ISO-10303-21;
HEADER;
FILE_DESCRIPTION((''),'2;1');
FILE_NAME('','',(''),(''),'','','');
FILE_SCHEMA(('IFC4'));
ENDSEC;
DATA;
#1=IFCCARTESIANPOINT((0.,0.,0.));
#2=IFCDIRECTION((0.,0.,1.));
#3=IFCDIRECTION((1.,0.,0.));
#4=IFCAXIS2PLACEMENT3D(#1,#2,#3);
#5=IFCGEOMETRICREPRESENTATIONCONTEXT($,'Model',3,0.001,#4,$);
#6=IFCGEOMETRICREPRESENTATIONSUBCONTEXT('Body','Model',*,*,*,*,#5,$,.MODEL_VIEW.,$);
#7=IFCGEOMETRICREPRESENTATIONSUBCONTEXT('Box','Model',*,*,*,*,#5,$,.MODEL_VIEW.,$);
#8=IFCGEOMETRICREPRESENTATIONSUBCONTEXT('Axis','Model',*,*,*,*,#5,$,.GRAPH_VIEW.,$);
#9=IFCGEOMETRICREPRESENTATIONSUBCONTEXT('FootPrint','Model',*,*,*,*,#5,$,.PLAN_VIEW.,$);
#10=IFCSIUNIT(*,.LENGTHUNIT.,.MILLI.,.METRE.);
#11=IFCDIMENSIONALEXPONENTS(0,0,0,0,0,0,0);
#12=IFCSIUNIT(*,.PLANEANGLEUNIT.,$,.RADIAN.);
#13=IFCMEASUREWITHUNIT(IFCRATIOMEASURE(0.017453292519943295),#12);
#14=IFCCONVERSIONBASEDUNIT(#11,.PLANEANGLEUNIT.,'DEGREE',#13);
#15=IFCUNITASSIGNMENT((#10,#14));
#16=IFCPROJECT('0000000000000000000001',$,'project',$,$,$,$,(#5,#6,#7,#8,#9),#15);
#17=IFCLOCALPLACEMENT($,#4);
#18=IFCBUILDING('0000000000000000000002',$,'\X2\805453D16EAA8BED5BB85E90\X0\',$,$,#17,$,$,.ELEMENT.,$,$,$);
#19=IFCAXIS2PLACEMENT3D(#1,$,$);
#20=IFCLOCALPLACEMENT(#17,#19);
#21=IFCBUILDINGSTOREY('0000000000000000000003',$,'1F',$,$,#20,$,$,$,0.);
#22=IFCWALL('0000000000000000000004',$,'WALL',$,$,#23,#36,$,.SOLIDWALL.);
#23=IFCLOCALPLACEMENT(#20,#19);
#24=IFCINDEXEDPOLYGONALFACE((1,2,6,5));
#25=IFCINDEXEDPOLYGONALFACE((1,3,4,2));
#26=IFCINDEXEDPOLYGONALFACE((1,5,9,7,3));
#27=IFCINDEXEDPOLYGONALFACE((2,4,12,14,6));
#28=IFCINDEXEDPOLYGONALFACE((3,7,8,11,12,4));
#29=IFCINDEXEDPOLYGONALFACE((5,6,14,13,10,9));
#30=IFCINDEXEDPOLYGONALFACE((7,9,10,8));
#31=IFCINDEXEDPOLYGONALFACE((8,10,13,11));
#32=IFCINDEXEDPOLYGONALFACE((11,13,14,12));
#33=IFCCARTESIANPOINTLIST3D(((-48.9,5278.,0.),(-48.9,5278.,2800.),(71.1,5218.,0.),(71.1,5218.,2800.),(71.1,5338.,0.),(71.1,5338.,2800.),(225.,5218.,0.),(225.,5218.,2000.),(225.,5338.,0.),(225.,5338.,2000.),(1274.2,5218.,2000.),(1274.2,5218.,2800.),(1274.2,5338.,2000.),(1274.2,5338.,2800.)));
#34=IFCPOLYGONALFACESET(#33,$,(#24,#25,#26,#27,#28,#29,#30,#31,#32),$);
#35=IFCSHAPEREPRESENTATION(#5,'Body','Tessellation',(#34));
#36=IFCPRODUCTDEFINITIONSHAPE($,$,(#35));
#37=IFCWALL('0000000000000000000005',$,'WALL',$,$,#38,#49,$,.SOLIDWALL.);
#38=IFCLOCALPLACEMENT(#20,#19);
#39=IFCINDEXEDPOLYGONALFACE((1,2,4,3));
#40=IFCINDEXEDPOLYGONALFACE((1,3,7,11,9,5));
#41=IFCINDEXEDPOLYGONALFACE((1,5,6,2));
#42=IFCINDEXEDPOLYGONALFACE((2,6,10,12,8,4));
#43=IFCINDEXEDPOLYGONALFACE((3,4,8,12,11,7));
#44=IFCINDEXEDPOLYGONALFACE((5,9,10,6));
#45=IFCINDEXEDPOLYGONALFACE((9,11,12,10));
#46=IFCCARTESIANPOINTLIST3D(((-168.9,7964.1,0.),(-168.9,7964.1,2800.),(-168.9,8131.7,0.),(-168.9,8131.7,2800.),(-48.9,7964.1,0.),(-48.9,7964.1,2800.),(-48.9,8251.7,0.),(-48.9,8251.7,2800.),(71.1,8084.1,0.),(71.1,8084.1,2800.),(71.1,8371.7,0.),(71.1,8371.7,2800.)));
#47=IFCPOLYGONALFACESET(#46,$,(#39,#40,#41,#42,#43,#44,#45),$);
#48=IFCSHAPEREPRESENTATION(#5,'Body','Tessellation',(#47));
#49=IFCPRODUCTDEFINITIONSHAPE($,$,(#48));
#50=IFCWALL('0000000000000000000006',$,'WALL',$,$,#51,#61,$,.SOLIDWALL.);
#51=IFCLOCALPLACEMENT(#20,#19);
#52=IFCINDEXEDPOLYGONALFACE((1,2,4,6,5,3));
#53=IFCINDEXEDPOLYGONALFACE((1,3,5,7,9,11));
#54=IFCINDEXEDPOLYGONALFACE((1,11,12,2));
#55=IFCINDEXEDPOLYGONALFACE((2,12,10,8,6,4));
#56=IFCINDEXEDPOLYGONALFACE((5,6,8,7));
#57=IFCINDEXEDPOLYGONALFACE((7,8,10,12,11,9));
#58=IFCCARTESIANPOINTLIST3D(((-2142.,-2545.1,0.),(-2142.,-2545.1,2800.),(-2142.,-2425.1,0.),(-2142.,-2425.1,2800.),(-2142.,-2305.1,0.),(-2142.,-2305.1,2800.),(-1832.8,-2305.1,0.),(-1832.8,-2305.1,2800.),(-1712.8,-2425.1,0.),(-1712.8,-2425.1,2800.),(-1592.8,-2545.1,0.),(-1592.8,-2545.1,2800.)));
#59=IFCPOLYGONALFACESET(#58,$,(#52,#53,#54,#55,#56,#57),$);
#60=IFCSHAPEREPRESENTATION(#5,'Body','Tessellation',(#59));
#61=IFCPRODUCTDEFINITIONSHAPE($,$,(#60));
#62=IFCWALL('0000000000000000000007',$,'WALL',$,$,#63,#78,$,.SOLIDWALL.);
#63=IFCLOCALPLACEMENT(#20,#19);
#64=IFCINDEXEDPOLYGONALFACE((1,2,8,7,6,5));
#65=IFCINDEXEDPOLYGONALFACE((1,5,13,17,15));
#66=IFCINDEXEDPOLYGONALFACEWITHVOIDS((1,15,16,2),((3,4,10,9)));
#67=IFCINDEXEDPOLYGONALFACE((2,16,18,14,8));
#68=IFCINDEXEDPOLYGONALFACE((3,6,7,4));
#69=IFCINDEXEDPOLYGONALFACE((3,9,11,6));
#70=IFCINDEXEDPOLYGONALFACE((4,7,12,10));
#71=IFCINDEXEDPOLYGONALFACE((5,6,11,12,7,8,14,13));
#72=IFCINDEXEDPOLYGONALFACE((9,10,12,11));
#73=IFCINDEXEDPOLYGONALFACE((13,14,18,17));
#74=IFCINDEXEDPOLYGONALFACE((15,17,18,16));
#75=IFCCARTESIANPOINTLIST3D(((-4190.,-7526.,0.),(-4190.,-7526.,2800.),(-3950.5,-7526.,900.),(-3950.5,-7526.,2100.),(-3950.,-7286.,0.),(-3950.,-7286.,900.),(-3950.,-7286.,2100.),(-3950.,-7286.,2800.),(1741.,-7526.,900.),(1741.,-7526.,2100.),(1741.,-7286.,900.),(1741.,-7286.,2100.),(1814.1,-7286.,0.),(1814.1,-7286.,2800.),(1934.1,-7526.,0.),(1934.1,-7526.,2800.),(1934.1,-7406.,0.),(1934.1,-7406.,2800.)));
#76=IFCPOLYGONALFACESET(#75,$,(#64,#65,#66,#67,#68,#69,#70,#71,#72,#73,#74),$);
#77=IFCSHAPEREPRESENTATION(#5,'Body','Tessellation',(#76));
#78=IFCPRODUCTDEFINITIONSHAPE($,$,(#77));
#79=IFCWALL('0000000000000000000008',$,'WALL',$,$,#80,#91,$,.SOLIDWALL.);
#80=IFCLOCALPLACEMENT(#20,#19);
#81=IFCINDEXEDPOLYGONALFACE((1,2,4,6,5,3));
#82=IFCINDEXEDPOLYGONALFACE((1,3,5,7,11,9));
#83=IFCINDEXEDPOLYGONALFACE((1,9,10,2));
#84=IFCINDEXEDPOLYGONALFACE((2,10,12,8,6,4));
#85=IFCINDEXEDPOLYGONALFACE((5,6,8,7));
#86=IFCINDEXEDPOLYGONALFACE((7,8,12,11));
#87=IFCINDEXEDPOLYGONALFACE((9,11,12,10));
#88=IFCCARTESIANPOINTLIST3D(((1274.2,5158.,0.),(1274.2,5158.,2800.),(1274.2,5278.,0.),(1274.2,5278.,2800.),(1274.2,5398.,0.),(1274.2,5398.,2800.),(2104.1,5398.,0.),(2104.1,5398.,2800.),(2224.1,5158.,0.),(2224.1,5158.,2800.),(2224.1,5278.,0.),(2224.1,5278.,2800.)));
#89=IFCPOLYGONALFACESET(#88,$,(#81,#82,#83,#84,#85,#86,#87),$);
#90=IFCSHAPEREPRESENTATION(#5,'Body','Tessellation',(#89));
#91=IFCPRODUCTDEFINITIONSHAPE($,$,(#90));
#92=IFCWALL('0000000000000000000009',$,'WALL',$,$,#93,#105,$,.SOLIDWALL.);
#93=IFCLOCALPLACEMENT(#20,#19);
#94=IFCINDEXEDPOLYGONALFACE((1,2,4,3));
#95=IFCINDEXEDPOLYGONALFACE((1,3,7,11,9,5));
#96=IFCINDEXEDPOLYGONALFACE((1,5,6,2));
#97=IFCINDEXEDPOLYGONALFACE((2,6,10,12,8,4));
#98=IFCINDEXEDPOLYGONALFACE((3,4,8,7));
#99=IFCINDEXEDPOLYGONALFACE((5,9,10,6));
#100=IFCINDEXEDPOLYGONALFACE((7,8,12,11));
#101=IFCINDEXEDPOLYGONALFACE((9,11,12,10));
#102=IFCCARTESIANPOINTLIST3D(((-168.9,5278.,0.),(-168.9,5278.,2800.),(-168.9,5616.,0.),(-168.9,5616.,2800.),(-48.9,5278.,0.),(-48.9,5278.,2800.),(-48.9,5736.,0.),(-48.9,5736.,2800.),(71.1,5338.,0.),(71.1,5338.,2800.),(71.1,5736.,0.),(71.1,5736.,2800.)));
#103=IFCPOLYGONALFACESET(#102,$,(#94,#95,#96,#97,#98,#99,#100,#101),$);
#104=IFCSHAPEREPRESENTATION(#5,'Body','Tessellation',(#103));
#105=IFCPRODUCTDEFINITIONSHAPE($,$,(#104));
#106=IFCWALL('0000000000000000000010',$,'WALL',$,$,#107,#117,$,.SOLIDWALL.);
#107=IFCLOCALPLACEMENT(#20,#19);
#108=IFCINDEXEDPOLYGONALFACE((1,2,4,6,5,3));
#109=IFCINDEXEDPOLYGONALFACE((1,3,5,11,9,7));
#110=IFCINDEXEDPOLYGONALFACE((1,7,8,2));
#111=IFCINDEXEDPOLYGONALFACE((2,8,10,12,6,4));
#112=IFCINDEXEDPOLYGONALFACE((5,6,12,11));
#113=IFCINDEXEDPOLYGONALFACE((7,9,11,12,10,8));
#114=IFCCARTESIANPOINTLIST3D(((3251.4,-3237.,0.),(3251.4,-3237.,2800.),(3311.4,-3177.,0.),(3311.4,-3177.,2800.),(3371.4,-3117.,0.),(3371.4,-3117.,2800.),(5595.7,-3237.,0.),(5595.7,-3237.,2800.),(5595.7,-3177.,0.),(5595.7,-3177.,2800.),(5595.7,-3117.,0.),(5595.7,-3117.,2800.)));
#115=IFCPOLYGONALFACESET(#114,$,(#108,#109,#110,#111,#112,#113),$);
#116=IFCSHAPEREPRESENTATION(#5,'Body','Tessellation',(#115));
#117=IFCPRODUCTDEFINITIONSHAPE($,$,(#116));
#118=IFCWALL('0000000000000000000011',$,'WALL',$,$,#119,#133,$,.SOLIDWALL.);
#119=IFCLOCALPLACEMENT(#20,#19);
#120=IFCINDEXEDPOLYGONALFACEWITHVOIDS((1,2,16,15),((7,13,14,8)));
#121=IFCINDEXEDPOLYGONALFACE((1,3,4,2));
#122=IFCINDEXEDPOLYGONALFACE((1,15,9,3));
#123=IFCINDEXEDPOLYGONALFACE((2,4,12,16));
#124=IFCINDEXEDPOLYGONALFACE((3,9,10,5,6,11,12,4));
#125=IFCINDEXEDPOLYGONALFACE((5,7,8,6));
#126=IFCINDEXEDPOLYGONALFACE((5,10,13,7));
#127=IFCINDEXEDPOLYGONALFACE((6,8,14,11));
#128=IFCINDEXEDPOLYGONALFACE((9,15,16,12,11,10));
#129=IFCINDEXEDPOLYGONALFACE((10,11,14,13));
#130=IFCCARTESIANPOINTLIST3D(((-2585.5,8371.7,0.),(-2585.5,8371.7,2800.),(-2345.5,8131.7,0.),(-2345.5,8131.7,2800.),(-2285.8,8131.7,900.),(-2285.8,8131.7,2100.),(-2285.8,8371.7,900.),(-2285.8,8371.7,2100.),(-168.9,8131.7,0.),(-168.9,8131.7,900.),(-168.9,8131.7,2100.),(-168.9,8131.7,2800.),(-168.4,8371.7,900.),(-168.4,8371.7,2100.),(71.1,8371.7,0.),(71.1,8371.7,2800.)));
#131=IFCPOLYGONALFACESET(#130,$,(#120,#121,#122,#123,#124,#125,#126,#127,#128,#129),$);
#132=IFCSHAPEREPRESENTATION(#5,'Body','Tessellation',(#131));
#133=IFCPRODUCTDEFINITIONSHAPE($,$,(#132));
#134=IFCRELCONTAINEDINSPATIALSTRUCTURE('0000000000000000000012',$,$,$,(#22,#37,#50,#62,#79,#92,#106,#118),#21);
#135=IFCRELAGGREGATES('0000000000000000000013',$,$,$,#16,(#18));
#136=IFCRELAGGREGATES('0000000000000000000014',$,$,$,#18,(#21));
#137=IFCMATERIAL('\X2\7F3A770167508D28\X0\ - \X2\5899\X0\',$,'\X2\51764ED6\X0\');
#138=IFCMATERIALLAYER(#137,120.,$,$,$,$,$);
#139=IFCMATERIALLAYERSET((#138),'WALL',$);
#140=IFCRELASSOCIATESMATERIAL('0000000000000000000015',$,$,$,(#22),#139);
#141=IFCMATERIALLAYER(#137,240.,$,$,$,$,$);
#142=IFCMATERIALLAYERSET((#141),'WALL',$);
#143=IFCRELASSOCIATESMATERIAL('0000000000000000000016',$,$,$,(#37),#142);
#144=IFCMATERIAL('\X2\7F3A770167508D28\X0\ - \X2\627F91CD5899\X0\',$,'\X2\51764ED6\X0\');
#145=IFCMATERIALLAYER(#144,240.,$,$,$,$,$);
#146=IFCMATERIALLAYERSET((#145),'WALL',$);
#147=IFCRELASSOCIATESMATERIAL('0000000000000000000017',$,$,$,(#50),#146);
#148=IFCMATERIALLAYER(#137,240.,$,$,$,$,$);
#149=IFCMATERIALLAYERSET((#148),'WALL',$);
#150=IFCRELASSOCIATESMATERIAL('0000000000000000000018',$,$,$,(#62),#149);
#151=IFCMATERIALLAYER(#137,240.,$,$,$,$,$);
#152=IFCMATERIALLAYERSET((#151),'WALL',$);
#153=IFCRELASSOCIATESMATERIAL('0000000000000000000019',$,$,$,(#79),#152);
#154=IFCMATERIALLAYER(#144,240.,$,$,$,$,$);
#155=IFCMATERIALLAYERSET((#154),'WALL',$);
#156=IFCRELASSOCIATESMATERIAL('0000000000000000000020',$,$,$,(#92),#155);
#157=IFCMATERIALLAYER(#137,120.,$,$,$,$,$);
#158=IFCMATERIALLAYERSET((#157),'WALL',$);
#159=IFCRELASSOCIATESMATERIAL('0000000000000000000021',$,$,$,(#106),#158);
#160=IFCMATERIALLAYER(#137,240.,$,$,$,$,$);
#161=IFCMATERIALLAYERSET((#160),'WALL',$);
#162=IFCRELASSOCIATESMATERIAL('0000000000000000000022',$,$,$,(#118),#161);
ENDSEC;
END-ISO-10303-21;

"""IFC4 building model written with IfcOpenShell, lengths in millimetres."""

from ifc_helpers import new_model, entity, si_unit, converted_unit, frame, origin, origin_with_axes, place, context, subcontext, project, spatial, polyline, segment, composite_curve, outline, extrude, material, layer, layer_set, layer_usage, element, save


model = new_model("IFC4")

# Units and contexts
model_context = context("Model", 3, precision=0.001, world=origin_with_axes())
body_context = subcontext(model_context, "Body", "Model", "MODEL_VIEW")
box_context = subcontext(model_context, "Box", "Model", "MODEL_VIEW")
axis_context = subcontext(model_context, "Axis", "Model", "GRAPH_VIEW")
footprint_context = subcontext(model_context, "FootPrint", "Model", "PLAN_VIEW")
ifc_project = project(units=[si_unit("LENGTHUNIT", "METRE", prefix="MILLI"), converted_unit("PLANEANGLEUNIT", "DEGREE", entity("IfcRatioMeasure", 0.017453292519943295), si_unit("PLANEANGLEUNIT", "RADIAN"), dimensions=[0, 0, 0, 0, 0, 0, 0])], contexts=[model_context, body_context, box_context, axis_context, footprint_context])

# Building, storey
building_placement = place(None, origin_with_axes())
building = spatial("IfcBuilding", under=ifc_project, at=building_placement, Name="联发溪语宸庐", CompositionType="ELEMENT")
storey_placement = place(building_placement, origin())
storey = spatial("IfcBuildingStorey", under=building, at=storey_placement, Name="1F", Elevation=0.0)

# Wall, opening
ifc_material_1 = material(Name="缺省材质 - 墙", Category="其他")
ifc_layer_1 = layer(ifc_material_1, 120.0)
ifc_layer_set_1 = layer_set([ifc_layer_1], Name="WALL")
ifc_layer_usage_1 = layer_usage(ifc_layer_set_1, "AXIS2", "NEGATIVE", 60.0)
wall_1_placement = place(None, origin_with_axes())
wall_1 = element("IfcWall", 1, at=wall_1_placement, inside=storey, material=ifc_layer_usage_1, Name="WALL", PredefinedType="SOLIDWALL", context=model_context, shape_type="SweptSolid", body=[
    extrude(outline(composite_curve([segment(polyline([(1274.2, 5278.0), (1274.2, 5338.0)]), True, "CONTINUOUS"), segment(polyline([(1274.2, 5338.0), (71.1, 5338.0)]), True, "CONTINUOUS"), segment(polyline([(71.1, 5338.0), (-48.9, 5278.0)]), True, "CONTINUOUS"), segment(polyline([(-48.9, 5278.0), (71.1, 5218.0)]), True, "CONTINUOUS"), segment(polyline([(71.1, 5218.0), (1274.2, 5218.0)]), True, "CONTINUOUS"), segment(polyline([(1274.2, 5218.0), (1274.2, 5278.0)]), True, "CONTINUOUS")], self_intersect=False)), origin(), (0.0, 0.0, 1.0), 2800.0),
])
opening_1_placement = place(None, origin_with_axes())
element("IfcOpeningElement", 2, at=opening_1_placement, cuts=wall_1, ObjectType="OPENING", PredefinedType="OPENING", context=model_context, shape_type="SweptSolid", body=[
    extrude(outline(composite_curve([segment(polyline([(225.0, 5218.0), (1274.2, 5218.0)]), True, "CONTINUOUS"), segment(polyline([(1274.2, 5218.0), (1274.2, 5338.0)]), True, "CONTINUOUS"), segment(polyline([(1274.2, 5338.0), (225.0, 5338.0)]), True, "CONTINUOUS"), segment(polyline([(225.0, 5338.0), (225.0, 5218.0)]), True, "CONTINUOUS")], self_intersect=False)), origin_with_axes(), (0.0, 0.0, 1.0), 2000.0),
])

# Walls
ifc_layer_2 = layer(ifc_material_1, 240.0)
ifc_layer_set_2 = layer_set([ifc_layer_2], Name="WALL")
ifc_layer_usage_2 = layer_usage(ifc_layer_set_2, "AXIS2", "NEGATIVE", 120.0)
wall_2_placement = place(None, origin_with_axes())
element("IfcWall", 3, at=wall_2_placement, inside=storey, material=ifc_layer_usage_2, Name="WALL", PredefinedType="SOLIDWALL", context=model_context, shape_type="SweptSolid", body=[
    extrude(outline(composite_curve([segment(polyline([(-48.9, 7964.1), (71.1, 8084.1)]), True, "CONTINUOUS"), segment(polyline([(71.1, 8084.1), (71.1, 8371.7)]), True, "CONTINUOUS"), segment(polyline([(71.1, 8371.7), (-48.9, 8251.7)]), True, "CONTINUOUS"), segment(polyline([(-48.9, 8251.7), (-168.9, 8131.7)]), True, "CONTINUOUS"), segment(polyline([(-168.9, 8131.7), (-168.9, 7964.1)]), True, "CONTINUOUS"), segment(polyline([(-168.9, 7964.1), (-48.9, 7964.1)]), True, "CONTINUOUS")], self_intersect=False)), origin(), (0.0, 0.0, 1.0), 2800.0),
])
ifc_material_2 = material(Name="缺省材质 - 承重墙", Category="其他")
ifc_layer_3 = layer(ifc_material_2, 240.0)
ifc_layer_set_3 = layer_set([ifc_layer_3], Name="WALL")
ifc_layer_usage_3 = layer_usage(ifc_layer_set_3, "AXIS2", "NEGATIVE", 120.0)
wall_3_placement = place(None, origin_with_axes())
element("IfcWall", 4, at=wall_3_placement, inside=storey, material=ifc_layer_usage_3, Name="WALL", PredefinedType="SOLIDWALL", context=model_context, shape_type="SweptSolid", body=[
    extrude(outline(composite_curve([segment(polyline([(-2142.0, -2425.1), (-2142.0, -2545.1)]), True, "CONTINUOUS"), segment(polyline([(-2142.0, -2545.1), (-1592.8, -2545.1)]), True, "CONTINUOUS"), segment(polyline([(-1592.8, -2545.1), (-1712.8, -2425.1)]), True, "CONTINUOUS"), segment(polyline([(-1712.8, -2425.1), (-1832.8, -2305.1)]), True, "CONTINUOUS"), segment(polyline([(-1832.8, -2305.1), (-2142.0, -2305.1)]), True, "CONTINUOUS"), segment(polyline([(-2142.0, -2305.1), (-2142.0, -2425.1)]), True, "CONTINUOUS")], self_intersect=False)), origin(), (0.0, 0.0, 1.0), 2800.0),
])

# Wall, opening
ifc_layer_4 = layer(ifc_material_1, 240.0)
ifc_layer_set_4 = layer_set([ifc_layer_4], Name="WALL")
ifc_layer_usage_4 = layer_usage(ifc_layer_set_4, "AXIS2", "NEGATIVE", 120.0)
wall_4_placement = place(None, origin_with_axes())
wall_4 = element("IfcWall", 5, at=wall_4_placement, inside=storey, material=ifc_layer_usage_4, Name="WALL", PredefinedType="SOLIDWALL", context=model_context, shape_type="SweptSolid", body=[
    extrude(outline(composite_curve([segment(polyline([(-4070.0, -7406.0), (-4190.0, -7526.0)]), True, "CONTINUOUS"), segment(polyline([(-4190.0, -7526.0), (1934.1, -7526.0)]), True, "CONTINUOUS"), segment(polyline([(1934.1, -7526.0), (1934.1, -7406.0)]), True, "CONTINUOUS"), segment(polyline([(1934.1, -7406.0), (1814.1, -7286.0)]), True, "CONTINUOUS"), segment(polyline([(1814.1, -7286.0), (-3950.0, -7286.0)]), True, "CONTINUOUS"), segment(polyline([(-3950.0, -7286.0), (-4070.0, -7406.0)]), True, "CONTINUOUS")], self_intersect=False)), origin(), (0.0, 0.0, 1.0), 2800.0),
])
opening_2_placement = place(None, origin_with_axes())
element("IfcOpeningElement", 6, at=opening_2_placement, cuts=wall_4, ObjectType="OPENING", PredefinedType="OPENING", context=model_context, shape_type="SweptSolid", body=[
    extrude(outline(composite_curve([segment(polyline([(1741.0, -7286.0), (-3950.0, -7286.0)]), True, "CONTINUOUS"), segment(polyline([(-3950.0, -7286.0), (-3950.5, -7526.0)]), True, "CONTINUOUS"), segment(polyline([(-3950.5, -7526.0), (1741.0, -7526.0)]), True, "CONTINUOUS"), segment(polyline([(1741.0, -7526.0), (1741.0, -7286.0)]), True, "CONTINUOUS")], self_intersect=False)), frame((0.0, 0.0, 900.0), z_axis=(0.0, 0.0, 1.0), x_axis=(1.0, 0.0, 0.0)), (0.0, 0.0, 1.0), 1200.0),
])

# Walls
ifc_layer_5 = layer(ifc_material_1, 240.0)
ifc_layer_set_5 = layer_set([ifc_layer_5], Name="WALL")
ifc_layer_usage_5 = layer_usage(ifc_layer_set_5, "AXIS2", "NEGATIVE", 120.0)
wall_5_placement = place(None, origin_with_axes())
element("IfcWall", 7, at=wall_5_placement, inside=storey, material=ifc_layer_usage_5, Name="WALL", PredefinedType="SOLIDWALL", context=model_context, shape_type="SweptSolid", body=[
    extrude(outline(composite_curve([segment(polyline([(2224.1, 5278.0), (2104.1, 5398.0)]), True, "CONTINUOUS"), segment(polyline([(2104.1, 5398.0), (1274.2, 5398.0)]), True, "CONTINUOUS"), segment(polyline([(1274.2, 5398.0), (1274.2, 5278.0)]), True, "CONTINUOUS"), segment(polyline([(1274.2, 5278.0), (1274.2, 5158.0)]), True, "CONTINUOUS"), segment(polyline([(1274.2, 5158.0), (2224.1, 5158.0)]), True, "CONTINUOUS"), segment(polyline([(2224.1, 5158.0), (2224.1, 5278.0)]), True, "CONTINUOUS")], self_intersect=False)), origin(), (0.0, 0.0, 1.0), 2800.0),
])
ifc_layer_6 = layer(ifc_material_2, 240.0)
ifc_layer_set_6 = layer_set([ifc_layer_6], Name="WALL")
ifc_layer_usage_6 = layer_usage(ifc_layer_set_6, "AXIS2", "NEGATIVE", 120.0)
wall_6_placement = place(None, origin_with_axes())
element("IfcWall", 8, at=wall_6_placement, inside=storey, material=ifc_layer_usage_6, Name="WALL", PredefinedType="SOLIDWALL", context=model_context, shape_type="SweptSolid", body=[
    extrude(outline(composite_curve([segment(polyline([(-48.9, 5278.0), (71.1, 5338.0)]), True, "CONTINUOUS"), segment(polyline([(71.1, 5338.0), (71.1, 5736.0)]), True, "CONTINUOUS"), segment(polyline([(71.1, 5736.0), (-48.9, 5736.0)]), True, "CONTINUOUS"), segment(polyline([(-48.9, 5736.0), (-168.9, 5616.0)]), True, "CONTINUOUS"), segment(polyline([(-168.9, 5616.0), (-168.9, 5278.0)]), True, "CONTINUOUS"), segment(polyline([(-168.9, 5278.0), (-48.9, 5278.0)]), True, "CONTINUOUS")], self_intersect=False)), origin(), (0.0, 0.0, 1.0), 2800.0),
])
ifc_layer_7 = layer(ifc_material_1, 120.0)
ifc_layer_set_7 = layer_set([ifc_layer_7], Name="WALL")
ifc_layer_usage_7 = layer_usage(ifc_layer_set_7, "AXIS2", "NEGATIVE", 60.0)
wall_7_placement = place(None, origin_with_axes())
element("IfcWall", 9, at=wall_7_placement, inside=storey, material=ifc_layer_usage_7, Name="WALL", PredefinedType="SOLIDWALL", context=model_context, shape_type="SweptSolid", body=[
    extrude(outline(composite_curve([segment(polyline([(3311.4, -3177.0), (3251.4, -3237.0)]), True, "CONTINUOUS"), segment(polyline([(3251.4, -3237.0), (5595.7, -3237.0)]), True, "CONTINUOUS"), segment(polyline([(5595.7, -3237.0), (5595.7, -3177.0)]), True, "CONTINUOUS"), segment(polyline([(5595.7, -3177.0), (5595.7, -3117.0)]), True, "CONTINUOUS"), segment(polyline([(5595.7, -3117.0), (3371.4, -3117.0)]), True, "CONTINUOUS"), segment(polyline([(3371.4, -3117.0), (3311.4, -3177.0)]), True, "CONTINUOUS")], self_intersect=False)), origin(), (0.0, 0.0, 1.0), 2800.0),
])

# Wall, opening
ifc_layer_8 = layer(ifc_material_1, 240.0)
ifc_layer_set_8 = layer_set([ifc_layer_8], Name="WALL")
ifc_layer_usage_8 = layer_usage(ifc_layer_set_8, "AXIS2", "NEGATIVE", 120.0)
wall_8_placement = place(None, origin_with_axes())
wall_8 = element("IfcWall", 10, at=wall_8_placement, inside=storey, material=ifc_layer_usage_8, Name="WALL", PredefinedType="SOLIDWALL", context=model_context, shape_type="SweptSolid", body=[
    extrude(outline(composite_curve([segment(polyline([(-2465.5, 8251.7), (-2345.5, 8131.7)]), True, "CONTINUOUS"), segment(polyline([(-2345.5, 8131.7), (-168.9, 8131.7)]), True, "CONTINUOUS"), segment(polyline([(-168.9, 8131.7), (-48.9, 8251.7)]), True, "CONTINUOUS"), segment(polyline([(-48.9, 8251.7), (71.1, 8371.7)]), True, "CONTINUOUS"), segment(polyline([(71.1, 8371.7), (-2585.5, 8371.7)]), True, "CONTINUOUS"), segment(polyline([(-2585.5, 8371.7), (-2465.5, 8251.7)]), True, "CONTINUOUS")], self_intersect=False)), origin(), (0.0, 0.0, 1.0), 2800.0),
])
opening_3_placement = place(None, origin_with_axes())
element("IfcOpeningElement", 11, at=opening_3_placement, cuts=wall_8, ObjectType="OPENING", PredefinedType="OPENING", context=model_context, shape_type="SweptSolid", body=[
    extrude(outline(composite_curve([segment(polyline([(-168.4, 8371.7), (-2285.8, 8371.7)]), True, "CONTINUOUS"), segment(polyline([(-2285.8, 8371.7), (-2285.8, 8131.7)]), True, "CONTINUOUS"), segment(polyline([(-2285.8, 8131.7), (-168.9, 8131.7)]), True, "CONTINUOUS"), segment(polyline([(-168.9, 8131.7), (-168.4, 8371.7)]), True, "CONTINUOUS")], self_intersect=False)), frame((0.0, 0.0, 900.0), z_axis=(0.0, 0.0, 1.0), x_axis=(1.0, 0.0, 0.0)), (0.0, 0.0, 1.0), 1200.0),
])

save(model, "model.ifc")
